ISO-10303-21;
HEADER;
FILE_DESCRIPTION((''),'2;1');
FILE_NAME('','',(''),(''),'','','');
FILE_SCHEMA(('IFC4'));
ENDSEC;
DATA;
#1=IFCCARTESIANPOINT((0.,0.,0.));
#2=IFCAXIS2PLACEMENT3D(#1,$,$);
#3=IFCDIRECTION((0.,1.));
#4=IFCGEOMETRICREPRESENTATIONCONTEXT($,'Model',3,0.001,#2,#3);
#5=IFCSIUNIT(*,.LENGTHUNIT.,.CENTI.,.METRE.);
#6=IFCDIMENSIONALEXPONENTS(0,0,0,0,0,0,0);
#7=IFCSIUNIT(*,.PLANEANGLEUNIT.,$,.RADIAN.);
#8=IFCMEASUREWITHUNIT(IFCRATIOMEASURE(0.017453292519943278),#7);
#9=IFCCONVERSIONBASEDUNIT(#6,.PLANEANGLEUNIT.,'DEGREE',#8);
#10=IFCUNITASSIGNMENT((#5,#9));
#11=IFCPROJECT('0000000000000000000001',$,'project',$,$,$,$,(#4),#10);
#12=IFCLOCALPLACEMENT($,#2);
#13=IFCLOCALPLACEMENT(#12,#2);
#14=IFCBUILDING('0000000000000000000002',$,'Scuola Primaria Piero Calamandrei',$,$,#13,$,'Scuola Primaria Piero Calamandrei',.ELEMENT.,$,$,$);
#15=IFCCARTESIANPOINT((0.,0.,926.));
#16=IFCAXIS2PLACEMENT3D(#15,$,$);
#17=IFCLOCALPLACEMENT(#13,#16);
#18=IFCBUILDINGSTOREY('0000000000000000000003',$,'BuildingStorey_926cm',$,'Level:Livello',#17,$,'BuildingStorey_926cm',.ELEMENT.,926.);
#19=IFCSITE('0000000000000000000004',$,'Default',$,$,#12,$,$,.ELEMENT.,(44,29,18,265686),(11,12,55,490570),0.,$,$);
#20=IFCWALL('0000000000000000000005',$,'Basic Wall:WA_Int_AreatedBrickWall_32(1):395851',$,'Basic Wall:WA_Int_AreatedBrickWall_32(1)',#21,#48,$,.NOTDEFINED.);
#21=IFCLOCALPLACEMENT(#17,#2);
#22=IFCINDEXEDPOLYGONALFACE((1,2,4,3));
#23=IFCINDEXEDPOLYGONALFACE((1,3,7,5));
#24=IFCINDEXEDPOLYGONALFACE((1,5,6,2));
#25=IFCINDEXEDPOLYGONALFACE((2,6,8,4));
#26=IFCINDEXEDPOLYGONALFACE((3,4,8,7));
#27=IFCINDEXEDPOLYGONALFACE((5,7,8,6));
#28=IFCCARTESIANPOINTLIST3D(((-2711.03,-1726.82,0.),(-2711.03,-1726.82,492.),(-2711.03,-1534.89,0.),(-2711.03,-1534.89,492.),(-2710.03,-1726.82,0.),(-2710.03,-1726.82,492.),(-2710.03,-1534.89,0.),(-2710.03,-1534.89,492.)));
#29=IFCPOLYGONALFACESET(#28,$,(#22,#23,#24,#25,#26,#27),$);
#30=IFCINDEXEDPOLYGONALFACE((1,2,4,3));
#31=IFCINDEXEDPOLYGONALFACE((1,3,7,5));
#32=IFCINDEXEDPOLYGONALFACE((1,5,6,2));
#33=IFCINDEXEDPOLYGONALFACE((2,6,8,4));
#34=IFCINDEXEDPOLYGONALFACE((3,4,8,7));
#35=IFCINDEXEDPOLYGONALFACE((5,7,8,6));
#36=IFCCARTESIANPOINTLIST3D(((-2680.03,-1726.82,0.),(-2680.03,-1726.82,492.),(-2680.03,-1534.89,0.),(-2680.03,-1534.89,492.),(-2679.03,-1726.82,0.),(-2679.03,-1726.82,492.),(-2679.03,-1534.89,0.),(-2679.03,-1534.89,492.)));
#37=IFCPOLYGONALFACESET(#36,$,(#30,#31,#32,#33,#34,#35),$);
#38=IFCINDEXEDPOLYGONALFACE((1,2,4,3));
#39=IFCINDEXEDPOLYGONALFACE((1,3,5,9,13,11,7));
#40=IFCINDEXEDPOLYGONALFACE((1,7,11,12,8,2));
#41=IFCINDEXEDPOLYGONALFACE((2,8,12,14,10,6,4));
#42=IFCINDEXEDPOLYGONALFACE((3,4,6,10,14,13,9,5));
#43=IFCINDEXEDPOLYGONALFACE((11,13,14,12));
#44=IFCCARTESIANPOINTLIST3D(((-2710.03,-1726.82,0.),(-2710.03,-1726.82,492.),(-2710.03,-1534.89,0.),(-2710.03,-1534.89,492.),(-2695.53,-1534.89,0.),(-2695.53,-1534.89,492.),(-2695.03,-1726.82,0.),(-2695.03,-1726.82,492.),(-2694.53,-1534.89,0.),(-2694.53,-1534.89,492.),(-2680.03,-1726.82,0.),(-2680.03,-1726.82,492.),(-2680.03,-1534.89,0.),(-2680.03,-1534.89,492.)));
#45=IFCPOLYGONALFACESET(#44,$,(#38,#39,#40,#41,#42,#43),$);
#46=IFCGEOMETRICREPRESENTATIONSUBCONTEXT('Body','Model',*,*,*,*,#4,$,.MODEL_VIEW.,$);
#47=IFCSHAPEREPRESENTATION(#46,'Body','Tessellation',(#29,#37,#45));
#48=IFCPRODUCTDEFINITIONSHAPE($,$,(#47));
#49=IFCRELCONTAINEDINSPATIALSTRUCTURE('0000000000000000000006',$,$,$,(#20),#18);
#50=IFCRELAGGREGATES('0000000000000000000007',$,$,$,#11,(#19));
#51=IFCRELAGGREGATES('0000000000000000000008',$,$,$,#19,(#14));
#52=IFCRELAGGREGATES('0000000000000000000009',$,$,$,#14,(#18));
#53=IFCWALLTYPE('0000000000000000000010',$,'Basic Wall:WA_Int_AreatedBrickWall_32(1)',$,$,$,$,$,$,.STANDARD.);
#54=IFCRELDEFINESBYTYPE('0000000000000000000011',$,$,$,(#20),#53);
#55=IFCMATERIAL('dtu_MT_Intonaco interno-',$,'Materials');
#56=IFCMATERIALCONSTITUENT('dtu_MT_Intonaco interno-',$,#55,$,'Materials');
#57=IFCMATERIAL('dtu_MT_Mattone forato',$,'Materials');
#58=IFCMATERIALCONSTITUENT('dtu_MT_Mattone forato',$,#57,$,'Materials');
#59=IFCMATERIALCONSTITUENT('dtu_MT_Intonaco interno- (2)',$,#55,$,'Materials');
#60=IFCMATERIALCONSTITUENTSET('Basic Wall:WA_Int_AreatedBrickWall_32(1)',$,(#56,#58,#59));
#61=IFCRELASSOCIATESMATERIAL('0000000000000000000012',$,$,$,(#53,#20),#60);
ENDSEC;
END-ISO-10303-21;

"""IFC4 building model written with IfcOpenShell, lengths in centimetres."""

from ifc_helpers import new_model, entity, si_unit, converted_unit, direction, frame, origin, place, context, subcontext, project, spatial, indexed_curve, outline, extrude, material, constituent, constituent_set, type_object, element, save


model = new_model("IFC4")

# Units and contexts
model_context = context("Model", 3, precision=0.001, world=origin(), true_north=direction((0.0, 1.0)))
body_context = subcontext(model_context, "Body", "Model", "MODEL_VIEW")
ifc_project = project(units=[si_unit("LENGTHUNIT", "METRE", prefix="CENTI"), converted_unit("PLANEANGLEUNIT", "DEGREE", entity("IfcRatioMeasure", 0.017453292519943278), si_unit("PLANEANGLEUNIT", "RADIAN"), dimensions=[0, 0, 0, 0, 0, 0, 0])], contexts=[model_context])

# Site, building, storey
site_placement = place(None, origin())
site = spatial("IfcSite", under=ifc_project, at=site_placement, Name="Default", CompositionType="ELEMENT", RefLatitude=(44, 29, 18, 265686), RefLongitude=(11, 12, 55, 490570), RefElevation=0.0)
building_placement = place(site_placement, origin())
building = spatial("IfcBuilding", under=site, at=building_placement, Name="Scuola Primaria Piero Calamandrei", LongName="Scuola Primaria Piero Calamandrei", CompositionType="ELEMENT")
storey_placement = place(building_placement, frame((0.0, 0.0, 926.0)))
storey = spatial("IfcBuildingStorey", under=building, at=storey_placement, Name="BuildingStorey_926cm", ObjectType="Level:Livello", LongName="BuildingStorey_926cm", CompositionType="ELEMENT", Elevation=926.0)

# Shared definitions
ifc_material_1 = material(Name="dtu_MT_Intonaco interno-", Category="Materials")
ifc_material_2 = material(Name="dtu_MT_Mattone forato", Category="Materials")

# Shared definitions
ifc_constituent_1 = constituent(ifc_material_1, Name="dtu_MT_Intonaco interno-", Category="Materials")
ifc_constituent_2 = constituent(ifc_material_2, Name="dtu_MT_Mattone forato", Category="Materials")
ifc_constituent_3 = constituent(ifc_material_1, Name="dtu_MT_Intonaco interno- (2)", Category="Materials")
ifc_constituent_set_1 = constituent_set(constituents=[ifc_constituent_1, ifc_constituent_2, ifc_constituent_3], Name="Basic Wall:WA_Int_AreatedBrickWall_32(1)")
wall_type_1 = type_object("IfcWallType", Name="Basic Wall:WA_Int_AreatedBrickWall_32(1)", PredefinedType="STANDARD", material=ifc_constituent_set_1)

# Wall
wall_1_placement = place(storey_placement, frame((-2695.03, -1534.89, 0.0), z_axis=(0.0, 0.0, 1.0), x_axis=(0.0, -1.0, 0.0)))
element("IfcWall", 1, at=wall_1_placement, inside=storey, type_object=wall_type_1, material=ifc_constituent_set_1, Name="Basic Wall:WA_Int_AreatedBrickWall_32(1):395851", ObjectType="Basic Wall:WA_Int_AreatedBrickWall_32(1)", PredefinedType="NOTDEFINED", context=body_context, shape_type="SweptSolid", body=[
    extrude(outline(indexed_curve([(-0.5, -95.96), (0.5, -95.96), (0.5, 95.96), (-0.5, 95.96), (-0.5, -95.96)], self_intersect=False)), frame((95.96, -15.5, 0.0), z_axis=(0.0, 0.0, 1.0), x_axis=(0.0, 1.0, 0.0)), (0.0, 0.0, 1.0), 492.0),
    extrude(outline(indexed_curve([(-0.5, -95.96), (0.5, -95.96), (0.5, 95.96), (-0.5, 95.96), (-0.5, -95.96)], self_intersect=False)), frame((95.96, 15.5, 0.0), z_axis=(0.0, 0.0, 1.0), x_axis=(0.0, -1.0, 0.0)), (0.0, 0.0, 1.0), 492.0),
    extrude(outline(indexed_curve([(0.5, -82.25), (15.0, -82.25), (15.0, 109.67), (0.0, 109.67), (-15.0, 109.67), (-15.0, -82.25), (-0.5, -82.25), (0.5, -82.25)], self_intersect=False)), frame((82.25, 0.0, 0.0), z_axis=(0.0, 0.0, 1.0), x_axis=(0.0, -1.0, 0.0)), (0.0, 0.0, 1.0), 492.0),
])

save(model, "model.ifc")
